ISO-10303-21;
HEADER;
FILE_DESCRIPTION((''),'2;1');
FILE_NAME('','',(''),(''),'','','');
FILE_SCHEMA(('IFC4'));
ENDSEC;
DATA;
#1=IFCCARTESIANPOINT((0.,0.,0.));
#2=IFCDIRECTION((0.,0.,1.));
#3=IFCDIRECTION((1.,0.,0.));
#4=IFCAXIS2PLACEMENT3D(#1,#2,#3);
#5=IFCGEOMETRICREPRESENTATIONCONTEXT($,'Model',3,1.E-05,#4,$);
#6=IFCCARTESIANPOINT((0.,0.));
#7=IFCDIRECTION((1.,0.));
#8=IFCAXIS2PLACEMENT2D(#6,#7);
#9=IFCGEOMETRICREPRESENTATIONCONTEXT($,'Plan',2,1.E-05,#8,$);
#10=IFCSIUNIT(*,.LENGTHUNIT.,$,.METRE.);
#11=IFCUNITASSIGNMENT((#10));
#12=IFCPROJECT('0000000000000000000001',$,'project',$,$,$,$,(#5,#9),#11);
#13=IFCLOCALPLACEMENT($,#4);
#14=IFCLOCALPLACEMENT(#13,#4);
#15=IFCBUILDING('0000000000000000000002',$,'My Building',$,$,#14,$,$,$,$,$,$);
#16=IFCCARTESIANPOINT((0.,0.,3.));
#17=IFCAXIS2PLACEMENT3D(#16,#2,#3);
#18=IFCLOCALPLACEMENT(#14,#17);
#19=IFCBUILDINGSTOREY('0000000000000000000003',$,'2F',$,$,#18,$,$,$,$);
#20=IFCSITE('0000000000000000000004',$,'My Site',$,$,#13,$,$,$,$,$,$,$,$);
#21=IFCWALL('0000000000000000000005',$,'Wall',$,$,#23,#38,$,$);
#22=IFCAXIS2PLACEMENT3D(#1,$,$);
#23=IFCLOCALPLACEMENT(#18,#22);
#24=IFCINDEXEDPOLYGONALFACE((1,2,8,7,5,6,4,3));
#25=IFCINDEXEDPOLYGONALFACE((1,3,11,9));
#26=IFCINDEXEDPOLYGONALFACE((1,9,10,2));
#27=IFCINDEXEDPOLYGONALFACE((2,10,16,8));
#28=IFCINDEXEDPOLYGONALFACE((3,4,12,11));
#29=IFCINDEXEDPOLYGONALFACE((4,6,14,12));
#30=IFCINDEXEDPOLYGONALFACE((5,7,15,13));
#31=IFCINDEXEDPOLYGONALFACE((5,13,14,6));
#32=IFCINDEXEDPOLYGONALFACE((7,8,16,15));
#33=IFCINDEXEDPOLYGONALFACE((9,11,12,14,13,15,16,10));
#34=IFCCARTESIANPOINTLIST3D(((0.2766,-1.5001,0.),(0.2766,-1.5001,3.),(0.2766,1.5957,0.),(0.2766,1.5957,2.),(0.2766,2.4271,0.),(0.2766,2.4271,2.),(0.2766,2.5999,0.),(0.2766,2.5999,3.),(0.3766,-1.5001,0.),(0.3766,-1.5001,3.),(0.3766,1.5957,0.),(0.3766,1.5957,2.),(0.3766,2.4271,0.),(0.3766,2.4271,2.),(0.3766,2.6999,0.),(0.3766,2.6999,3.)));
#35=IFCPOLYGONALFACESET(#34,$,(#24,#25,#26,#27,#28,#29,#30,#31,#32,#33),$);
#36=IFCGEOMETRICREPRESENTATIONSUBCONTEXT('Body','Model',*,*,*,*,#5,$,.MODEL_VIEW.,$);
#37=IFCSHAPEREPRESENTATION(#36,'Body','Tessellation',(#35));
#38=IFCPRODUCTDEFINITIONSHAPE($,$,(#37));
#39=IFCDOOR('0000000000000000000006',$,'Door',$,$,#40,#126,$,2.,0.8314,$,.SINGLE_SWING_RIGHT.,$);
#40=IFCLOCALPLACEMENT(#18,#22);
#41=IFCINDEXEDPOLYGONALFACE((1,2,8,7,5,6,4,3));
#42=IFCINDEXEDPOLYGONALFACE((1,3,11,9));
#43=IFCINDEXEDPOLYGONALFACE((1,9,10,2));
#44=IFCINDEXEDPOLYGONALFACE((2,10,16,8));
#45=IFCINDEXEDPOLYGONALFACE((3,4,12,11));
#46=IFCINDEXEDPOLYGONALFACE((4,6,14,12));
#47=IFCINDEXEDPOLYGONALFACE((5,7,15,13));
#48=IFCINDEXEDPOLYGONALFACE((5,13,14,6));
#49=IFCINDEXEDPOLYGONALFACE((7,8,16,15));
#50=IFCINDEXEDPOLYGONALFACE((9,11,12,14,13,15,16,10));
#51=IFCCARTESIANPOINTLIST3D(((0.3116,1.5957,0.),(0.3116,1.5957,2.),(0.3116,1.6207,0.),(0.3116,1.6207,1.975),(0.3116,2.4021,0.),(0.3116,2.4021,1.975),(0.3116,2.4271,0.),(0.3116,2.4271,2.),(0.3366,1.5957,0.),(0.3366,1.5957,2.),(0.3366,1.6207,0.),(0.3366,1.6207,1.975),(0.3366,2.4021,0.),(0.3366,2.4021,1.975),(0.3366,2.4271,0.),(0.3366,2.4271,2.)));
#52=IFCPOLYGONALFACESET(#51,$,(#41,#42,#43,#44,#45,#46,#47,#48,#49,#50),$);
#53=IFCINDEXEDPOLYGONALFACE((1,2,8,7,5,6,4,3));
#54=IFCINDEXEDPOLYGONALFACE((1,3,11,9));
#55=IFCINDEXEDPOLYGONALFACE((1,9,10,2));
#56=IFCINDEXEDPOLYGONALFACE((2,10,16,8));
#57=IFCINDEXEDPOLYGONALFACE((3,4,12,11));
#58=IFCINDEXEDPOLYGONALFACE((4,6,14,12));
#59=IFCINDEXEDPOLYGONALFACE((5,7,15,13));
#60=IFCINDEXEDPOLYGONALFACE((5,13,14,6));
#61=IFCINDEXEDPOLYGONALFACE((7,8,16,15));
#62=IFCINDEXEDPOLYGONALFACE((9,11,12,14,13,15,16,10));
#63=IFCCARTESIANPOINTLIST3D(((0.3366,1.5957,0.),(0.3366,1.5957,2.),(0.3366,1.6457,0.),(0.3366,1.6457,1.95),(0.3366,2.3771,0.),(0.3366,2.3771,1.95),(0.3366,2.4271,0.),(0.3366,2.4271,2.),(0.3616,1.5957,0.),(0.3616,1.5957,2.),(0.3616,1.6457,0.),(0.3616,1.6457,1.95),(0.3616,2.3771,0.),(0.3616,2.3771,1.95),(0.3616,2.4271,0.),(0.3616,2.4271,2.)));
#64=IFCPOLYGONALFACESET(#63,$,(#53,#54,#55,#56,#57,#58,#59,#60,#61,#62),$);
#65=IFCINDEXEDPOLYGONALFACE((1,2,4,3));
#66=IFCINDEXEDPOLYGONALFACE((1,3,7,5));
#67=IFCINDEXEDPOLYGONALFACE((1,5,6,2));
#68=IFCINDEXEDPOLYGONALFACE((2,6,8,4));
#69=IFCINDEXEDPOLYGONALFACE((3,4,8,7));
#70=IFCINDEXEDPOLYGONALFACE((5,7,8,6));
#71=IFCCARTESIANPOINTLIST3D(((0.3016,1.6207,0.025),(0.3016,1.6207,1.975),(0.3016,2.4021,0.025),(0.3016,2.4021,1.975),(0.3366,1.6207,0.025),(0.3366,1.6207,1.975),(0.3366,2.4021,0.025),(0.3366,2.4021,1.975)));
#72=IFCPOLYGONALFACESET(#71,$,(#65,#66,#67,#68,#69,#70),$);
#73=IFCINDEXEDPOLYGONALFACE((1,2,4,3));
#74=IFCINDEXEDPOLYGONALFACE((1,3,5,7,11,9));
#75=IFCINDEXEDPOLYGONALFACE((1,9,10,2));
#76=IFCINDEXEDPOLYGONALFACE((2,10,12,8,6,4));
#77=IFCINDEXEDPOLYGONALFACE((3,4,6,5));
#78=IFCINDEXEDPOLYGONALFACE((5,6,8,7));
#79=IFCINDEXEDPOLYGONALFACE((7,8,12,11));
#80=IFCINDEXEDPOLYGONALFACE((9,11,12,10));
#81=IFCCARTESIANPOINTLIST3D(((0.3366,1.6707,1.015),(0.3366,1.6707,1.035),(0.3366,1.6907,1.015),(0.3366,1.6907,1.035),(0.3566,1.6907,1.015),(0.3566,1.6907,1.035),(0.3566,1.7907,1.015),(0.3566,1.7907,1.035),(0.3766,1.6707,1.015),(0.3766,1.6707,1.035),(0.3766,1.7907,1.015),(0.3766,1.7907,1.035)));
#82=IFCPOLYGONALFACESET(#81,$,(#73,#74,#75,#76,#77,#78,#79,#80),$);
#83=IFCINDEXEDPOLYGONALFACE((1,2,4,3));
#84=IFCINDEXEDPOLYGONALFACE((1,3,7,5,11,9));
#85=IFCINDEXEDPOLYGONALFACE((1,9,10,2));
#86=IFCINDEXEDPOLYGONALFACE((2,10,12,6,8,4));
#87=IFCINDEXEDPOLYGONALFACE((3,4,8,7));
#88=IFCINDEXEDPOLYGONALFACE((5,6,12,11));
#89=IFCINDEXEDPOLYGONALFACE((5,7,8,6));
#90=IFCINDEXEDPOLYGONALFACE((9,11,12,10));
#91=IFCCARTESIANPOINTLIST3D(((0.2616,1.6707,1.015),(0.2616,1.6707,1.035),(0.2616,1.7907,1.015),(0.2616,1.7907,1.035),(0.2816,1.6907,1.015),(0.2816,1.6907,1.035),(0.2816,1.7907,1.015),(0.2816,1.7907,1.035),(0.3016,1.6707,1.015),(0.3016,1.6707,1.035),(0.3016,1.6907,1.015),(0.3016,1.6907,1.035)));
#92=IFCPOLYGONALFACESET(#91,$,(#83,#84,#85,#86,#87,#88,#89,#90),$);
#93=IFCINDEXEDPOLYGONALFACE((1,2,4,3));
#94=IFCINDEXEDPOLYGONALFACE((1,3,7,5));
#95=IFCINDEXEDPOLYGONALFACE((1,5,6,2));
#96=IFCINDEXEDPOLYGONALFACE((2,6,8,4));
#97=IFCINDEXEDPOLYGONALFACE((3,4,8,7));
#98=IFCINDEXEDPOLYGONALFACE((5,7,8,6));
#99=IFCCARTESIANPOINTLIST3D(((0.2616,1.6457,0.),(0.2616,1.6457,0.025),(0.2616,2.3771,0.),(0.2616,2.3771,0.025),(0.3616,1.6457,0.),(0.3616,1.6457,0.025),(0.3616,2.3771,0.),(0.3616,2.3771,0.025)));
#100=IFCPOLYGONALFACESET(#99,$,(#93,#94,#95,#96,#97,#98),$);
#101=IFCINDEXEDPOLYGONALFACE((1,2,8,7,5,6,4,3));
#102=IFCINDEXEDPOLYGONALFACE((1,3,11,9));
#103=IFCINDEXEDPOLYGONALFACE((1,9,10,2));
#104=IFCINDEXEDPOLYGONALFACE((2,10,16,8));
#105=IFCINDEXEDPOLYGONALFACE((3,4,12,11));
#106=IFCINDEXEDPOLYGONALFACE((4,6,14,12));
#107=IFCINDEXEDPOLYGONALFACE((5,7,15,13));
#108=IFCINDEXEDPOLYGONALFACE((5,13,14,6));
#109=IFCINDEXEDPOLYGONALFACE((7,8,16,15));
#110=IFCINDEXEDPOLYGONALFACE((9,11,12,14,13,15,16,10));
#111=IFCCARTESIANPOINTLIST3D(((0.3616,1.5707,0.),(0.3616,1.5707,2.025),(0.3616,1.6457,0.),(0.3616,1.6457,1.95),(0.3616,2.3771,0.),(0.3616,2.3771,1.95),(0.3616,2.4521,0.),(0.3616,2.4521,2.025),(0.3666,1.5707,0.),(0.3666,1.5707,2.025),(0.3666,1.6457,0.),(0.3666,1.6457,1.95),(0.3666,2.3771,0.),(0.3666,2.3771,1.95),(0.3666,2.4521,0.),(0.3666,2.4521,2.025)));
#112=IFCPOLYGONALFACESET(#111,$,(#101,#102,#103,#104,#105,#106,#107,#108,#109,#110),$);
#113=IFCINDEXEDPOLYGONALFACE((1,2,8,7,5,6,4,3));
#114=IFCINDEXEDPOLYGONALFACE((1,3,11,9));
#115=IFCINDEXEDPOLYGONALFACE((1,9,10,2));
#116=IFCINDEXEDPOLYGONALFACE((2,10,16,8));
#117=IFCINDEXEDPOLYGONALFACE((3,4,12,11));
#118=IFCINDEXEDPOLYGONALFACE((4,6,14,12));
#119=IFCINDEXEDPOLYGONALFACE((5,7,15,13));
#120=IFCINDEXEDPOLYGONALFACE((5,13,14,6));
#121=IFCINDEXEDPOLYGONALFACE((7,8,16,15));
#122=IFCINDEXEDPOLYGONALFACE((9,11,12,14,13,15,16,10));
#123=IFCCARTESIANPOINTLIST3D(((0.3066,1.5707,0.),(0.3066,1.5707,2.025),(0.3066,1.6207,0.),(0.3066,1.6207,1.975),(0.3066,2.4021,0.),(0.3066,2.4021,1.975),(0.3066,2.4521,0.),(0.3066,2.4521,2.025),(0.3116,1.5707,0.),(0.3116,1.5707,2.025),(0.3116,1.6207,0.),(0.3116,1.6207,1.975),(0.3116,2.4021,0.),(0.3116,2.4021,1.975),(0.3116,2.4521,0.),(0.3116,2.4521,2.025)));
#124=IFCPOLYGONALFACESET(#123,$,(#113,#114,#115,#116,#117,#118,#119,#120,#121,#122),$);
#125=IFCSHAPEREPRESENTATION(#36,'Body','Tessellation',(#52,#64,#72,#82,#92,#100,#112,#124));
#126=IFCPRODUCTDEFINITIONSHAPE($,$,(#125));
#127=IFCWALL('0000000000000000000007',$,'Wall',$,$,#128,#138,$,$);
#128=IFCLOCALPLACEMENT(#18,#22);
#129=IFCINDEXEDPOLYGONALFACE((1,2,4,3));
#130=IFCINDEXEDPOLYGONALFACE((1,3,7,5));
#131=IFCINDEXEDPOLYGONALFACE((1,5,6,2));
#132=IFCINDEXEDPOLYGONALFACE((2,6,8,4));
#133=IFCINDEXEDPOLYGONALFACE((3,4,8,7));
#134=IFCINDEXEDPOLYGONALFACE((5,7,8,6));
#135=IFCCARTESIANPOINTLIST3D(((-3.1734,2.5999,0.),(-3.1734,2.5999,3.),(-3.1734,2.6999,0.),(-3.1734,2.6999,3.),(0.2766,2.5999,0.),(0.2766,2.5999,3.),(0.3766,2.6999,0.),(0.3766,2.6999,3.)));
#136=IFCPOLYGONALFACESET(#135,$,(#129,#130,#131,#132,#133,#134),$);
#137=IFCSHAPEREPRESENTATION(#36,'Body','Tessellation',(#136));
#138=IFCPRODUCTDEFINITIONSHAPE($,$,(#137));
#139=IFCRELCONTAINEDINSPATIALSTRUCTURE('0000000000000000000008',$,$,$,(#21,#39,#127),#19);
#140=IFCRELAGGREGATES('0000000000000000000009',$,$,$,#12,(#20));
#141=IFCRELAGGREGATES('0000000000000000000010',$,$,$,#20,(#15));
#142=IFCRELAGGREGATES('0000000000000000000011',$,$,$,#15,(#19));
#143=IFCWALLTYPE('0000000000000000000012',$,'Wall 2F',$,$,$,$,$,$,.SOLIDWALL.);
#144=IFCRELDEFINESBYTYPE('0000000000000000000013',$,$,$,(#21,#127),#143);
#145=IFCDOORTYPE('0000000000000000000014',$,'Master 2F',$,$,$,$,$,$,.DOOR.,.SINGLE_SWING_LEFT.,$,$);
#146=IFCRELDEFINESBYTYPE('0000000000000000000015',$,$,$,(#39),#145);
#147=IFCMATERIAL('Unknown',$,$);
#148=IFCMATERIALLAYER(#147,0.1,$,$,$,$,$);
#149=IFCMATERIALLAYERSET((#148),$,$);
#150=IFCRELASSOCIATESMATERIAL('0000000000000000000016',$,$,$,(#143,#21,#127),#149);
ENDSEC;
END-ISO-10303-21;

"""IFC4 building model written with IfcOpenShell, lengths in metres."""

from ifc_helpers import new_model, entity, si_unit, frame, origin_with_axes, origin_2d_with_axis, place, context, subcontext, project, spatial, line, indexed_curve, outline, extrude, shape, source, transform, mapped, material, layer, layer_set, layer_usage, type_object, type_shapes, element, fill, save


model = new_model("IFC4")

# Units and contexts
model_context = context("Model", 3, precision=1e-05, world=origin_with_axes())
plan_context = context("Plan", 2, precision=1e-05, world=origin_2d_with_axis())
body_context_1 = subcontext(model_context, "Body", "Model", "MODEL_VIEW")
body_context_2 = subcontext(plan_context, "Body", "Plan", "PLAN_VIEW")
ifc_project = project(units=[si_unit("LENGTHUNIT", "METRE")], contexts=[model_context, plan_context])

# Site, building, storey
site_placement = place(None, origin_with_axes())
site = spatial("IfcSite", under=ifc_project, at=site_placement, Name="My Site")
building_placement = place(site_placement, origin_with_axes())
building = spatial("IfcBuilding", under=site, at=building_placement, Name="My Building")
storey_placement = place(building_placement, frame((0.0, 0.0, 3.0), z_axis=(0.0, 0.0, 1.0), x_axis=(1.0, 0.0, 0.0)))
storey = spatial("IfcBuildingStorey", under=building, at=storey_placement, Name="2F")

# Shared definitions
ifc_material = material(Name="Unknown")

# Shared definitions
ifc_layer = layer(ifc_material, 0.1)
ifc_layer_set = layer_set([ifc_layer])
wall_type = type_object("IfcWallType", Name="Wall 2F", PredefinedType="SOLIDWALL", material=ifc_layer_set)

# Wall, opening, door
ifc_layer_usage_1 = layer_usage(ifc_layer_set, "AXIS2", "POSITIVE", 0.0)
wall_1_placement = place(storey_placement, frame((0.3766, -1.6001, 0.0), z_axis=(0.0, 0.0, 1.0), x_axis=(0.0, 1.0, 0.0)))
wall_1 = element("IfcWall", 1, at=wall_1_placement, inside=storey, type_object=wall_type, material=ifc_layer_usage_1, Name="Wall", context=body_context_1, shape_type="SweptSolid", body=[
    extrude(outline(indexed_curve([(0.1, 0.0), (0.1, 0.1), (4.2, 0.1), (4.3, 0.0)], segments=[line(1, 2, 3, 4, 1)])), origin_with_axes(), (0.0, 0.0, 1.0), 3.0),
])
shared_shape_1 = source(origin_with_axes(), body_context_1, "Body", "SweptSolid", [
    extrude(outline(indexed_curve([(0.0, 0.0), (0.8314, 0.0), (0.8314, 2.0), (0.0, 2.0)], segments=[line(1, 2, 3, 4, 1)])), frame((0.0, -0.6, 0.0), z_axis=(0.0, -1.0, 0.0), x_axis=(1.0, 0.0, 0.0)), (0.0, 0.0, -1.0), 1.2),
])
opening_1_placement = place(wall_1_placement, frame((3.1958, 0.015, 0.0), z_axis=(0.0, 0.0, 1.0), x_axis=(1.0, 0.0, 0.0)))
opening_1 = element("IfcOpeningElement", 2, at=opening_1_placement, cuts=wall_1, PredefinedType="OPENING", context=body_context_1, shape_type="MappedRepresentation", body=[
    mapped(shared_shape_1, transform((0.0, 0.0, 0.0), x_axis=(1.0, 0.0, 0.0), y_axis=(0.0, 1.0, 0.0), z_axis=(0.0, 0.0, 1.0), scale=1.0)),
])
door_type_1 = type_object("IfcDoorType", Name="Master 2F", OperationType="SINGLE_SWING_LEFT", PredefinedType="DOOR")
shared_shape_2 = source(origin_with_axes(), body_context_1, "Body", "SweptSolid", [
    extrude(outline(indexed_curve([(0.0, 0.0), (0.0, 2.0), (0.8314, 2.0), (0.8314, 0.0), (0.8064, 0.0), (0.8064, 1.975), (0.025, 1.975), (0.025, 0.0)], segments=[line(1, 2, 3, 4, 5, 6, 7, 8, 1)])), frame((0.0, 0.025, 0.0), z_axis=(0.0, -1.0, 0.0), x_axis=(1.0, 0.0, 0.0)), (0.0, 0.0, -1.0), 0.025),
    extrude(outline(indexed_curve([(0.0, 0.0), (0.0, 2.0), (0.8314, 2.0), (0.8314, 0.0), (0.7814, 0.0), (0.7814, 1.95), (0.05, 1.95), (0.05, 0.0)], segments=[line(1, 2, 3, 4, 5, 6, 7, 8, 1)])), frame((0.0, 0.0, 0.0), z_axis=(0.0, -1.0, 0.0), x_axis=(1.0, 0.0, 0.0)), (0.0, 0.0, -1.0), 0.025),
    extrude(outline(indexed_curve([(0.0, 0.0), (0.7814, 0.0), (0.7814, 0.035), (0.0, 0.035)], segments=[line(1, 2, 3, 4, 1)])), frame((0.025, 0.025, 0.025), z_axis=(0.0, 0.0, 1.0), x_axis=(1.0, 0.0, 0.0)), (0.0, 0.0, 1.0), 1.95),
    extrude(outline(indexed_curve([(0.0, 0.0), (0.0, -0.04), (0.12, -0.04), (0.12, -0.02), (0.02, -0.02), (0.02, 0.0)], segments=[line(1, 2, 3, 4, 5, 6, 1)])), frame((0.075, 0.025, 1.015), z_axis=(0.0, 0.0, 1.0), x_axis=(1.0, 0.0, 0.0)), (0.0, 0.0, 1.0), 0.02),
    extrude(outline(indexed_curve([(0.0, 0.0), (0.0, 0.04), (0.12, 0.04), (0.12, 0.02), (0.02, 0.02), (0.02, 0.0)], segments=[line(1, 2, 3, 4, 5, 6, 1)])), frame((0.075, 0.06, 1.015), z_axis=(0.0, 0.0, 1.0), x_axis=(1.0, 0.0, 0.0)), (0.0, 0.0, 1.0), 0.02),
    extrude(outline(indexed_curve([(0.0, 0.0), (0.7314, 0.0), (0.7314, 0.1), (0.0, 0.1)], segments=[line(1, 2, 3, 4, 1)])), frame((0.05, 0.0, 0.0), z_axis=(0.0, 0.0, 1.0), x_axis=(1.0, 0.0, 0.0)), (0.0, 0.0, 1.0), 0.025),
    extrude(outline(indexed_curve([(0.0, 0.0), (0.0, 2.025), (0.8814, 2.025), (0.8814, 0.0), (0.8064, 0.0), (0.8064, 1.95), (0.075, 1.95), (0.075, 0.0)], segments=[line(1, 2, 3, 4, 5, 6, 7, 8, 1)])), frame((-0.025, -0.005, 0.0), z_axis=(0.0, -1.0, 0.0), x_axis=(1.0, 0.0, 0.0)), (0.0, 0.0, -1.0), 0.005),
    extrude(outline(indexed_curve([(0.0, 0.0), (0.0, 2.025), (0.8814, 2.025), (0.8814, 0.0), (0.8314, 0.0), (0.8314, 1.975), (0.05, 1.975), (0.05, 0.0)], segments=[line(1, 2, 3, 4, 5, 6, 7, 8, 1)])), frame((-0.025, 0.05, 0.0), z_axis=(0.0, -1.0, 0.0), x_axis=(1.0, 0.0, 0.0)), (0.0, 0.0, -1.0), 0.005),
])
shared_shape_3 = source(origin_with_axes(), body_context_2, "Body", "Curve2D", [
    entity("IfcIndexedPolyCurve", entity("IfcCartesianPointList2D", [[0.0, 0.0], [0.0, 0.05], [0.025, 0.05], [0.025, 0.025], [0.05, 0.025], [0.05, 0.0]]), [entity("IfcLineIndex", [1, 2, 3, 4, 5, 6, 1])]),
    entity("IfcIndexedPolyCurve", entity("IfcCartesianPointList2D", [[0.8314, 0.0], [0.8314, 0.05], [0.8064, 0.05], [0.8064, 0.025], [0.7814, 0.025], [0.7814, 0.0]]), [entity("IfcLineIndex", [1, 2, 3, 4, 5, 6, 1])]),
    entity("IfcTrimmedCurve", entity("IfcEllipse", entity("IfcAxis2Placement2D", entity("IfcCartesianPoint", [0.7714, 0.05]), entity("IfcDirection", [1.0, 0.0])), 0.7464, 0.7814), [entity("IfcCartesianPoint", [0.7714, 0.8314])], [entity("IfcCartesianPoint", [0.025, 0.05])], True, "CARTESIAN"),
    entity("IfcIndexedPolyCurve", entity("IfcCartesianPointList2D", [[0.8064, 0.05], [0.7714, 0.05], [0.7714, 0.8314], [0.8064, 0.8314]]), [entity("IfcLineIndex", [1, 2, 3, 4, 1])]),
])
type_shapes(door_type_1, [shared_shape_2, shared_shape_3])
door_1_placement = place(opening_1_placement, frame((0.0, 0.0, 0.0), z_axis=(0.0, 0.0, 1.0), x_axis=(1.0, 0.0, 0.0)))
door_1 = element("IfcDoor", 3, at=door_1_placement, inside=storey, type_object=door_type_1, Name="Door", OperationType="SINGLE_SWING_RIGHT", OverallHeight=2.0, OverallWidth=0.8314, shapes=[
    shape(body_context_1, "Body", "MappedRepresentation", [mapped(shared_shape_2, transform((0.0, 0.0, 0.0), x_axis=(1.0, 0.0, 0.0), y_axis=(0.0, 1.0, 0.0), z_axis=(0.0, 0.0, 1.0), scale=1.0))]),
    shape(body_context_2, "Body", "MappedRepresentation", [mapped(shared_shape_3, transform((0.0, 0.0, 0.0), x_axis=(1.0, 0.0, 0.0), y_axis=(0.0, 1.0, 0.0), z_axis=(0.0, 0.0, 1.0), scale=1.0))]),
])
fill(opening_1, door_1)

# Wall
ifc_layer_usage_2 = layer_usage(ifc_layer_set, "AXIS2", "POSITIVE", 0.0)
wall_2_placement = place(storey_placement, frame((0.3766, 2.6999, 0.0), z_axis=(0.0, 0.0, 1.0), x_axis=(-1.0, 0.0, 0.0)))
element("IfcWall", 4, at=wall_2_placement, inside=storey, type_object=wall_type, material=ifc_layer_usage_2, Name="Wall", context=body_context_1, shape_type="SweptSolid", body=[
    extrude(outline(indexed_curve([(0.0, 0.0), (0.1, 0.1), (3.55, 0.1), (3.55, 0.0)], segments=[line(1, 2, 3, 4, 1)])), origin_with_axes(), (0.0, 0.0, 1.0), 3.0),
])

save(model, "model.ifc")
